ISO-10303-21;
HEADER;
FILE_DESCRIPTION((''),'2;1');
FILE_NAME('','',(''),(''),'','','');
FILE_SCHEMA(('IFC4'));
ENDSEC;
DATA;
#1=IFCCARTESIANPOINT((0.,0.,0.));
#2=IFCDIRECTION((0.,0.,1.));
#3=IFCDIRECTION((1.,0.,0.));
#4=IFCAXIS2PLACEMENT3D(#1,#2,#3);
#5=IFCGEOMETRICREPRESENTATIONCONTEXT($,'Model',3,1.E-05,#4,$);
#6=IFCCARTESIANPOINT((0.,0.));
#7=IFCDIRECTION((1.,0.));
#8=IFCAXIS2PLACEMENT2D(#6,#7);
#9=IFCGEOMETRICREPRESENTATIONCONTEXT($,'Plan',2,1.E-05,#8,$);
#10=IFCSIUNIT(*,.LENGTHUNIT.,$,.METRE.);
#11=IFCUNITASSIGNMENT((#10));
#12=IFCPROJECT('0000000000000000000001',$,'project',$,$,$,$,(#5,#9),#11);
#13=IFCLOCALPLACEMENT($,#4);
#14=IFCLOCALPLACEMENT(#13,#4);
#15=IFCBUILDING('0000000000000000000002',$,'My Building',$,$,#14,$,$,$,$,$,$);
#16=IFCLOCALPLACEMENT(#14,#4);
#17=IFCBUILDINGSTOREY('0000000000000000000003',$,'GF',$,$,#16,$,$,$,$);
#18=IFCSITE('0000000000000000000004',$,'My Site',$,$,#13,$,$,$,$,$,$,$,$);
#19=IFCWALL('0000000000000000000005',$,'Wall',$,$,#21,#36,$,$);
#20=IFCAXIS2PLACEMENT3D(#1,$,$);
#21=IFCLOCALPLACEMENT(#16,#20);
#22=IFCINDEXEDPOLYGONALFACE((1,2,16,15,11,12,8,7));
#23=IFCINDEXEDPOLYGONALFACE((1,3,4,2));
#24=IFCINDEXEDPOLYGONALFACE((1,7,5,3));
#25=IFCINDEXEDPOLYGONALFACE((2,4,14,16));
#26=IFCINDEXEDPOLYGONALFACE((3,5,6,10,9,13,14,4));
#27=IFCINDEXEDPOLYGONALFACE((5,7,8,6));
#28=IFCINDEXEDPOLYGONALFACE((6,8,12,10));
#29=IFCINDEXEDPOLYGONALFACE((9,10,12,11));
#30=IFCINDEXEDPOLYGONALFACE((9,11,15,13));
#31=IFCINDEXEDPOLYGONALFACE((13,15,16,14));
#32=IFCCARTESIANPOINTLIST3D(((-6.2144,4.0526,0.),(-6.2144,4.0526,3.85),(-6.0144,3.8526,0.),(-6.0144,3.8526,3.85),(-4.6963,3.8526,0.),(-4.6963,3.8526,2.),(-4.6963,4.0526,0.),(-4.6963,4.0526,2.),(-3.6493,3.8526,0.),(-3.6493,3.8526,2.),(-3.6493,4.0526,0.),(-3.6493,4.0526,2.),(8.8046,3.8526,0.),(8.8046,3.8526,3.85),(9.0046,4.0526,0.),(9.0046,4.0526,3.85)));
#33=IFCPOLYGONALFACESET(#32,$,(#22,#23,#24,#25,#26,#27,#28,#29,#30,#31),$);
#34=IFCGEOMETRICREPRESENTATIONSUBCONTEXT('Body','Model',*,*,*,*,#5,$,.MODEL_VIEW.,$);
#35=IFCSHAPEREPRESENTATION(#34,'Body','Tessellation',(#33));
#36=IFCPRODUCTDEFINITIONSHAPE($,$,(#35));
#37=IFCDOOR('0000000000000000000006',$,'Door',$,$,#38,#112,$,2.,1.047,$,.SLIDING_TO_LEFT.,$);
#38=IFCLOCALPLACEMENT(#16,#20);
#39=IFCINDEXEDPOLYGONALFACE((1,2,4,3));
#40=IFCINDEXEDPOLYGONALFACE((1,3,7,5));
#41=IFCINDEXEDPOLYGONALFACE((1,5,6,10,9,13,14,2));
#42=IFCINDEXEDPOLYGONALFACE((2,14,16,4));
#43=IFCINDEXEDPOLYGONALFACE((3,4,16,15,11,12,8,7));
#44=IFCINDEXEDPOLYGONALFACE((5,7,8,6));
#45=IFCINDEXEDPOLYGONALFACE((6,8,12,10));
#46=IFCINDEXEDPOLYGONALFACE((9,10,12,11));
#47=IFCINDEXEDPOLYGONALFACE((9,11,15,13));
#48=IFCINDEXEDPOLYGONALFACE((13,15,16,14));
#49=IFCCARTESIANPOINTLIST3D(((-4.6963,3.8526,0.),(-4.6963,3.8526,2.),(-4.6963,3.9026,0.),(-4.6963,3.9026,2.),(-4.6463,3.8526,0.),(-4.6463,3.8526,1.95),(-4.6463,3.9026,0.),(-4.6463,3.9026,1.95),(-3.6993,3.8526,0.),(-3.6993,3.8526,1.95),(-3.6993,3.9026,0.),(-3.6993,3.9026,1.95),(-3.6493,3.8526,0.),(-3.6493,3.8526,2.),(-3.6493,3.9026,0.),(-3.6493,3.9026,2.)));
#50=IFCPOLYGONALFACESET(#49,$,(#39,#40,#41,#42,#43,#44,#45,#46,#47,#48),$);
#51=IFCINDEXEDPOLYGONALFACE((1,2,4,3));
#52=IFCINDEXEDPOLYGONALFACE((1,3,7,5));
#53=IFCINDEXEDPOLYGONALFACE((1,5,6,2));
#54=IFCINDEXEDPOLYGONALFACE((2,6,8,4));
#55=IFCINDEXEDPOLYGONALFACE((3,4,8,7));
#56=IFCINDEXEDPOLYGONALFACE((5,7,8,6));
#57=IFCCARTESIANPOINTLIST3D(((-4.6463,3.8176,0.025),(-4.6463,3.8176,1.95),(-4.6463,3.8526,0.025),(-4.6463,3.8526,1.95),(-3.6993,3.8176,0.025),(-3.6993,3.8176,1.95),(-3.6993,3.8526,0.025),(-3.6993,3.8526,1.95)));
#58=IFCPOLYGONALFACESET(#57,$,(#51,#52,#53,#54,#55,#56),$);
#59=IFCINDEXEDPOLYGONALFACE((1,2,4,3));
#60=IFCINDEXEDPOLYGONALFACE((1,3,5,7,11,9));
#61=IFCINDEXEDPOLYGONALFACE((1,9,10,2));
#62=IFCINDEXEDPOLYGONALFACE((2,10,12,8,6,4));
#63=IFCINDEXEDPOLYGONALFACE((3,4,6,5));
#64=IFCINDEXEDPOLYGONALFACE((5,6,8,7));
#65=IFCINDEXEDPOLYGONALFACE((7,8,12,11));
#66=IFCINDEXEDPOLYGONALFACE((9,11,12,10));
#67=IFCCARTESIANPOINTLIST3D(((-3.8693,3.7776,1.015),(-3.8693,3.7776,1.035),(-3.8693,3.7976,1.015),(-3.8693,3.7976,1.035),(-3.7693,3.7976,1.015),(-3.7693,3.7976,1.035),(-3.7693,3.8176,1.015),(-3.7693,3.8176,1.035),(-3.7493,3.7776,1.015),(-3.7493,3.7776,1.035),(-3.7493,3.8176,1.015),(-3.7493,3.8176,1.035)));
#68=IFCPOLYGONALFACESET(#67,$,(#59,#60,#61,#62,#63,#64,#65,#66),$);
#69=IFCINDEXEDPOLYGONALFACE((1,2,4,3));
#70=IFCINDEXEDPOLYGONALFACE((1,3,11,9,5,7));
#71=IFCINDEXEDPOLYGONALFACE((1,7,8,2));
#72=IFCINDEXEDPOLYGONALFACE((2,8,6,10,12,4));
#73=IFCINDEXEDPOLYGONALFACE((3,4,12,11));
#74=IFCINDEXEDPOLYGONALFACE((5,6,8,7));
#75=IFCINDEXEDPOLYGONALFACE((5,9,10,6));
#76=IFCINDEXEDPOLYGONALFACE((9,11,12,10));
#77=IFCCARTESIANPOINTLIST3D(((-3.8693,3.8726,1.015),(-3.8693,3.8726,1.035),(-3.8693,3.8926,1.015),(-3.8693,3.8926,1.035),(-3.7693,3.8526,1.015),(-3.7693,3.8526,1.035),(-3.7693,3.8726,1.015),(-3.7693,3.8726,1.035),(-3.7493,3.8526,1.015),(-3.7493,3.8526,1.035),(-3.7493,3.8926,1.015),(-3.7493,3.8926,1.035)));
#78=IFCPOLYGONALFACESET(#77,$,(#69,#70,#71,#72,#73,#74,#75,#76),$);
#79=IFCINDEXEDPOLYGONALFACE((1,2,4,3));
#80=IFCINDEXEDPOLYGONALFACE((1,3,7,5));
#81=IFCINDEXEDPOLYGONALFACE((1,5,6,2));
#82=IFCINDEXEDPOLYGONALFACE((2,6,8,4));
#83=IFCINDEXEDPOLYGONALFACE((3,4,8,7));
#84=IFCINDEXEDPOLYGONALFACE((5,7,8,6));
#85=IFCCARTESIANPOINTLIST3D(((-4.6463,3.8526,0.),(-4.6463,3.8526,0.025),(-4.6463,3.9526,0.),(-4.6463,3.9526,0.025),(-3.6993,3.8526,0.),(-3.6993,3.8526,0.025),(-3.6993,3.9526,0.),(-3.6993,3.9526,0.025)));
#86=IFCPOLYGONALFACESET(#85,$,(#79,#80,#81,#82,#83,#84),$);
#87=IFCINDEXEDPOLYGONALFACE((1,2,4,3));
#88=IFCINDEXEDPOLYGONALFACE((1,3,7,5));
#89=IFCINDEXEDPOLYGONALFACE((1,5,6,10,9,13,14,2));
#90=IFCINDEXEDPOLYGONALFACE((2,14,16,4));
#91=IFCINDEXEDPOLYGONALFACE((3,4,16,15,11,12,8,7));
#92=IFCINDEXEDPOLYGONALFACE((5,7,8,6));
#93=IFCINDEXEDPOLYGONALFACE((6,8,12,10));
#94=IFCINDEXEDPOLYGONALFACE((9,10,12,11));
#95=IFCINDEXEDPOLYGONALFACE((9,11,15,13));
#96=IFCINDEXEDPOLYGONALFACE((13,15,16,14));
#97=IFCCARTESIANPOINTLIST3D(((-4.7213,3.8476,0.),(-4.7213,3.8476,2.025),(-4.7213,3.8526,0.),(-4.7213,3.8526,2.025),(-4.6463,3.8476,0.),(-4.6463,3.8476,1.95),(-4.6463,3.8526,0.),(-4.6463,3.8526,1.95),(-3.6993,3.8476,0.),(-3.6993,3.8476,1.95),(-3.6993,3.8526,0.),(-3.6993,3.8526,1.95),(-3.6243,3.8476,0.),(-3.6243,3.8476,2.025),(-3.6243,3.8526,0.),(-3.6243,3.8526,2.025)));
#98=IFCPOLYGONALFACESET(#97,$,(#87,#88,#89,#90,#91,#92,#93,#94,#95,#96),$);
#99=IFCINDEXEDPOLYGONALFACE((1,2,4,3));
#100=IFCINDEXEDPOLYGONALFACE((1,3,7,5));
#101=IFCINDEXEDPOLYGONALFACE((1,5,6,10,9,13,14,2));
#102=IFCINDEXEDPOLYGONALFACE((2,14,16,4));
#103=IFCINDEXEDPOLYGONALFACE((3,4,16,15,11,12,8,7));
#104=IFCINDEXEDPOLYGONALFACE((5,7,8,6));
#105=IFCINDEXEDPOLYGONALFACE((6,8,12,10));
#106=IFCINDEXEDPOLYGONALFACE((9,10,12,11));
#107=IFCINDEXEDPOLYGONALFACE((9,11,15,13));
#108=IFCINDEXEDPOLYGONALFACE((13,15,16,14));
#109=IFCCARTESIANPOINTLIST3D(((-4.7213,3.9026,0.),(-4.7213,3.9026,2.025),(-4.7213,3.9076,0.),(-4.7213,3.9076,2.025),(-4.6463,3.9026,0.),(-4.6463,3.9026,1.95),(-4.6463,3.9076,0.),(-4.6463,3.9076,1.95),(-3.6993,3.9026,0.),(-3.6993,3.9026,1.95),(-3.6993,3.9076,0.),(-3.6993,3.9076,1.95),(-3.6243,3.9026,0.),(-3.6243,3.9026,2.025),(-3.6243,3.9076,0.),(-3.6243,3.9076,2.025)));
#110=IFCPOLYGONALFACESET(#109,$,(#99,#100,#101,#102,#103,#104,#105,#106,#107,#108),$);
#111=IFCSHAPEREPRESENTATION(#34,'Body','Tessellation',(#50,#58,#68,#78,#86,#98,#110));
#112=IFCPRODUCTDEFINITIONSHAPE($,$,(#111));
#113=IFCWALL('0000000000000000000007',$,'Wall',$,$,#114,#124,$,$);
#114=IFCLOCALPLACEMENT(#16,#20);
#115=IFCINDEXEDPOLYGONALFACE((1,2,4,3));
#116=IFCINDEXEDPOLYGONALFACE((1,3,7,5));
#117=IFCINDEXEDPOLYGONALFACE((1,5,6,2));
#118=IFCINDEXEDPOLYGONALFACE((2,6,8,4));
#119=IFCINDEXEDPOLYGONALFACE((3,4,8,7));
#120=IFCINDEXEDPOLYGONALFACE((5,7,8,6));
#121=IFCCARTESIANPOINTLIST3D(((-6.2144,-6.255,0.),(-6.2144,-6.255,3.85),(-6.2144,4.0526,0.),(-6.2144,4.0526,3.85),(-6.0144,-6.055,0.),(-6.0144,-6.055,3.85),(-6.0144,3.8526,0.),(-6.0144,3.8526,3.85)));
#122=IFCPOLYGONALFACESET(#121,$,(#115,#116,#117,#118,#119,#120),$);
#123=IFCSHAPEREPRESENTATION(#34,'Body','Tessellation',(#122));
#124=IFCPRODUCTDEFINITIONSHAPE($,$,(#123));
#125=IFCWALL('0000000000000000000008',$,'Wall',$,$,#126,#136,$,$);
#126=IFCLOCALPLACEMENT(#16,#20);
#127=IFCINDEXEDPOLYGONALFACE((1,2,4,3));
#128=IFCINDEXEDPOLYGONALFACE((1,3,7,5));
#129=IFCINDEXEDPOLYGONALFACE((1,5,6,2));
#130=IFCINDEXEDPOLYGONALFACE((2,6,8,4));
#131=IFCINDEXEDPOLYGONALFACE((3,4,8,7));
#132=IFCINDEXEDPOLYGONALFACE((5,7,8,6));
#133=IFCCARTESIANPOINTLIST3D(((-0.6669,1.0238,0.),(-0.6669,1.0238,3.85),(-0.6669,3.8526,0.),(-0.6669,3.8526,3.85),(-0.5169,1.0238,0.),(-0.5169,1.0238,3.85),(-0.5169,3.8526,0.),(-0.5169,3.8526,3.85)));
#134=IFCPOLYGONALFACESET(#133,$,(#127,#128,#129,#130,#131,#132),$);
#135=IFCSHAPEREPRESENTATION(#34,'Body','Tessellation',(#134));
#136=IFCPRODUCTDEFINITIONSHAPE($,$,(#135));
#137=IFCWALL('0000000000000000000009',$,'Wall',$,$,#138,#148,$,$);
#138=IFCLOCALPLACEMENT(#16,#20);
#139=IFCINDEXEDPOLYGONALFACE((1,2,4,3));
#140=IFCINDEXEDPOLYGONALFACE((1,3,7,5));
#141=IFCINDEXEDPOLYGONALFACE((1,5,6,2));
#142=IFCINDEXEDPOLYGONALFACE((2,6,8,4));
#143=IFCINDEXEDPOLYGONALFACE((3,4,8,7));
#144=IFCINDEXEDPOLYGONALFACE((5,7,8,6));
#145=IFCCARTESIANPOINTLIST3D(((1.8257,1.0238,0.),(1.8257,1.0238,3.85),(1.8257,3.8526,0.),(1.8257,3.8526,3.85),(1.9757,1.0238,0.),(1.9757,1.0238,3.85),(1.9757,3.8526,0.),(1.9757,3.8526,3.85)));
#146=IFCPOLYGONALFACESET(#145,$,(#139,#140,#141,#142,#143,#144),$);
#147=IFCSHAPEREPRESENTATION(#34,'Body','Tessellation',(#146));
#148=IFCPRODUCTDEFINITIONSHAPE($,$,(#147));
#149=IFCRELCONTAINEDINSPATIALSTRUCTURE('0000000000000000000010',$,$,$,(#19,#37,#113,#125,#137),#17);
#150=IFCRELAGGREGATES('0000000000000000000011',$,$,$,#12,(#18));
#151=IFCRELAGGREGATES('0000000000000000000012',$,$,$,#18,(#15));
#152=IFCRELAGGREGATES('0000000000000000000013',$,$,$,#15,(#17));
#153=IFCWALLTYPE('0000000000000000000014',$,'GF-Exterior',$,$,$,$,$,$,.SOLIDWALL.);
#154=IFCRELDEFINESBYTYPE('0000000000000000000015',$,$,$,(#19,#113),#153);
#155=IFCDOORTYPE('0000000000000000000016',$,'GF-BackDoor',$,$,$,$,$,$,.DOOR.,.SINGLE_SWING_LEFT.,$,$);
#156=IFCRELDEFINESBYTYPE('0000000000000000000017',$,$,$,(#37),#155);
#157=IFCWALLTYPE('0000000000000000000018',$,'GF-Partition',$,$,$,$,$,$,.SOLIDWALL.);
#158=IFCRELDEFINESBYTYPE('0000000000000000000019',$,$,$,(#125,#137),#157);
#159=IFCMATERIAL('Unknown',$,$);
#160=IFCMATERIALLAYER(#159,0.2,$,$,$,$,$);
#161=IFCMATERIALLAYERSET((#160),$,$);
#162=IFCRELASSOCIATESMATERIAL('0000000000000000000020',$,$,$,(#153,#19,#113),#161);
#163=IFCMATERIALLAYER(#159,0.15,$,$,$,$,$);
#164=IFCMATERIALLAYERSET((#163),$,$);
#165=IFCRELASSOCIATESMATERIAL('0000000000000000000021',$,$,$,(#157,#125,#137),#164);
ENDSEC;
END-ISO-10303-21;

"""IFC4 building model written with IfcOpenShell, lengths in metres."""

from ifc_helpers import new_model, entity, si_unit, frame, origin_with_axes, origin_2d_with_axis, place, context, subcontext, project, spatial, line, indexed_curve, outline, extrude, shape, source, transform, mapped, material, layer, layer_set, layer_usage, type_object, type_shapes, element, fill, save


model = new_model("IFC4")

# Units and contexts
model_context = context("Model", 3, precision=1e-05, world=origin_with_axes())
plan_context = context("Plan", 2, precision=1e-05, world=origin_2d_with_axis())
body_context_1 = subcontext(model_context, "Body", "Model", "MODEL_VIEW")
body_context_2 = subcontext(plan_context, "Body", "Plan", "PLAN_VIEW")
ifc_project = project(units=[si_unit("LENGTHUNIT", "METRE")], contexts=[model_context, plan_context])

# Site, building, storey
site_placement = place(None, origin_with_axes())
site = spatial("IfcSite", under=ifc_project, at=site_placement, Name="My Site")
building_placement = place(site_placement, origin_with_axes())
building = spatial("IfcBuilding", under=site, at=building_placement, Name="My Building")
storey_placement = place(building_placement, origin_with_axes())
storey = spatial("IfcBuildingStorey", under=building, at=storey_placement, Name="GF")

# Shared definitions
ifc_material = material(Name="Unknown")

# Wall, opening, door
ifc_layer_1 = layer(ifc_material, 0.2)
ifc_layer_set_1 = layer_set([ifc_layer_1])
ifc_layer_usage_1 = layer_usage(ifc_layer_set_1, "AXIS2", "POSITIVE", 0.0)
wall_type_1 = type_object("IfcWallType", Name="GF-Exterior", PredefinedType="SOLIDWALL", material=ifc_layer_set_1)
wall_1_placement = place(storey_placement, frame((-6.0144, 3.8526, 0.0), z_axis=(0.0, 0.0, 1.0), x_axis=(1.0, 0.0, 0.0)))
wall_1 = element("IfcWall", 1, at=wall_1_placement, inside=storey, type_object=wall_type_1, material=ifc_layer_usage_1, Name="Wall", context=body_context_1, shape_type="SweptSolid", body=[
    extrude(outline(indexed_curve([(0.0, 0.0), (-0.2, 0.2), (15.019, 0.2), (14.819, 0.0)], segments=[line(1, 2, 3, 4, 1)])), origin_with_axes(), (0.0, 0.0, 1.0), 3.85),
])
shared_shape_1 = source(origin_with_axes(), body_context_1, "Body", "SweptSolid", [
    extrude(outline(indexed_curve([(0.0, 0.0), (1.047, 0.0), (1.047, 2.0), (0.0, 2.0)], segments=[line(1, 2, 3, 4, 1)])), frame((0.0, -0.6, 0.0), z_axis=(0.0, -1.0, 0.0), x_axis=(1.0, 0.0, 0.0)), (0.0, 0.0, -1.0), 1.2),
])
opening_placement = place(wall_1_placement, frame((1.3181, 0.0, 0.0), z_axis=(0.0, 0.0, 1.0), x_axis=(1.0, 0.0, 0.0)))
opening = element("IfcOpeningElement", 2, at=opening_placement, cuts=wall_1, PredefinedType="OPENING", context=body_context_1, shape_type="MappedRepresentation", body=[
    mapped(shared_shape_1, transform((0.0, 0.0, 0.0), x_axis=(1.0, 0.0, 0.0), y_axis=(0.0, 1.0, 0.0), z_axis=(0.0, 0.0, 1.0), scale=1.0)),
])
door_type = type_object("IfcDoorType", Name="GF-BackDoor", OperationType="SINGLE_SWING_LEFT", PredefinedType="DOOR")
shared_shape_2 = source(origin_with_axes(), body_context_1, "Body", "SweptSolid", [
    extrude(outline(indexed_curve([(0.0, 0.0), (0.0, 2.0), (1.047, 2.0), (1.047, 0.0), (0.997, 0.0), (0.997, 1.95), (0.05, 1.95), (0.05, 0.0)], segments=[line(1, 2, 3, 4, 5, 6, 7, 8, 1)])), frame((0.0, 0.0, 0.0), z_axis=(0.0, -1.0, 0.0), x_axis=(1.0, 0.0, 0.0)), (0.0, 0.0, -1.0), 0.05),
    extrude(outline(indexed_curve([(0.0, 0.0), (0.947, 0.0), (0.947, 0.035), (0.0, 0.035)], segments=[line(1, 2, 3, 4, 1)])), frame((0.05, -0.035, 0.025), z_axis=(0.0, 0.0, 1.0), x_axis=(1.0, 0.0, 0.0)), (0.0, 0.0, 1.0), 1.925),
    extrude(outline(indexed_curve([(0.0, 0.0), (0.0, -0.04), (-0.12, -0.04), (-0.12, -0.02), (-0.02, -0.02), (-0.02, 0.0)], segments=[line(1, 2, 3, 4, 5, 6, 1)])), frame((0.947, -0.035, 1.015), z_axis=(0.0, 0.0, 1.0), x_axis=(1.0, 0.0, 0.0)), (0.0, 0.0, 1.0), 0.02),
    extrude(outline(indexed_curve([(0.0, 0.0), (0.0, 0.04), (-0.12, 0.04), (-0.12, 0.02), (-0.02, 0.02), (-0.02, 0.0)], segments=[line(1, 2, 3, 4, 5, 6, 1)])), frame((0.947, 0.0, 1.015), z_axis=(0.0, 0.0, 1.0), x_axis=(1.0, 0.0, 0.0)), (0.0, 0.0, 1.0), 0.02),
    extrude(outline(indexed_curve([(0.0, 0.0), (0.947, 0.0), (0.947, 0.1), (0.0, 0.1)], segments=[line(1, 2, 3, 4, 1)])), frame((0.05, 0.0, 0.0), z_axis=(0.0, 0.0, 1.0), x_axis=(1.0, 0.0, 0.0)), (0.0, 0.0, 1.0), 0.025),
    extrude(outline(indexed_curve([(0.0, 0.0), (0.0, 2.025), (1.097, 2.025), (1.097, 0.0), (1.022, 0.0), (1.022, 1.95), (0.075, 1.95), (0.075, 0.0)], segments=[line(1, 2, 3, 4, 5, 6, 7, 8, 1)])), frame((-0.025, -0.005, 0.0), z_axis=(0.0, -1.0, 0.0), x_axis=(1.0, 0.0, 0.0)), (0.0, 0.0, -1.0), 0.005),
    extrude(outline(indexed_curve([(0.0, 0.0), (0.0, 2.025), (1.097, 2.025), (1.097, 0.0), (1.022, 0.0), (1.022, 1.95), (0.075, 1.95), (0.075, 0.0)], segments=[line(1, 2, 3, 4, 5, 6, 7, 8, 1)])), frame((-0.025, 0.05, 0.0), z_axis=(0.0, -1.0, 0.0), x_axis=(1.0, 0.0, 0.0)), (0.0, 0.0, -1.0), 0.005),
])
shared_shape_3 = source(origin_with_axes(), body_context_2, "Body", "Curve2D", [
    entity("IfcIndexedPolyCurve", entity("IfcCartesianPointList2D", [[0.0, 0.0], [0.05, 0.0], [0.05, 0.05], [0.0, 0.05]]), [entity("IfcLineIndex", [1, 2, 3, 4, 1])]),
    entity("IfcIndexedPolyCurve", entity("IfcCartesianPointList2D", [[1.047, 0.0], [0.997, 0.0], [0.997, 0.05], [1.047, 0.05]]), [entity("IfcLineIndex", [1, 2, 3, 4, 1])]),
    entity("IfcIndexedPolyCurve", entity("IfcCartesianPointList2D", [[-0.4235, -0.035], [0.5235, -0.035], [0.5235, 0.0], [-0.4235, 0.0]]), [entity("IfcLineIndex", [1, 2, 3, 4, 1])]),
])
type_shapes(door_type, [shared_shape_2, shared_shape_3])
door_placement = place(opening_placement, frame((0.0, 0.0, 0.0), z_axis=(0.0, 0.0, 1.0), x_axis=(1.0, 0.0, 0.0)))
door = element("IfcDoor", 3, at=door_placement, inside=storey, type_object=door_type, Name="Door", OperationType="SLIDING_TO_LEFT", OverallHeight=2.0, OverallWidth=1.047, shapes=[
    shape(body_context_1, "Body", "MappedRepresentation", [mapped(shared_shape_2, transform((0.0, 0.0, 0.0), x_axis=(1.0, 0.0, 0.0), y_axis=(0.0, 1.0, 0.0), z_axis=(0.0, 0.0, 1.0), scale=1.0))]),
    shape(body_context_2, "Body", "MappedRepresentation", [mapped(shared_shape_3, transform((0.0, 0.0, 0.0), x_axis=(1.0, 0.0, 0.0), y_axis=(0.0, 1.0, 0.0), z_axis=(0.0, 0.0, 1.0), scale=1.0))]),
])
fill(opening, door)

# Walls
ifc_layer_usage_2 = layer_usage(ifc_layer_set_1, "AXIS2", "POSITIVE", 0.0)
wall_2_placement = place(storey_placement, frame((-6.0144, -6.055, 0.0), z_axis=(0.0, 0.0, 1.0), x_axis=(0.0, 1.0, 0.0)))
element("IfcWall", 4, at=wall_2_placement, inside=storey, type_object=wall_type_1, material=ifc_layer_usage_2, Name="Wall", context=body_context_1, shape_type="SweptSolid", body=[
    extrude(outline(indexed_curve([(0.0, 0.0), (-0.2, 0.2), (10.1077, 0.2), (9.9077, 0.0)], segments=[line(1, 2, 3, 4, 1)])), origin_with_axes(), (0.0, 0.0, 1.0), 3.85),
])
ifc_layer_2 = layer(ifc_material, 0.15)
ifc_layer_set_2 = layer_set([ifc_layer_2])
ifc_layer_usage_3 = layer_usage(ifc_layer_set_2, "AXIS2", "POSITIVE", 0.0)
wall_type_2 = type_object("IfcWallType", Name="GF-Partition", PredefinedType="SOLIDWALL", material=ifc_layer_set_2)
wall_3_placement = place(storey_placement, frame((-0.5169, 1.0238, 0.0), z_axis=(0.0, 0.0, 1.0), x_axis=(0.0, 1.0, 0.0)))
element("IfcWall", 5, at=wall_3_placement, inside=storey, type_object=wall_type_2, material=ifc_layer_usage_3, Name="Wall", context=body_context_1, shape_type="SweptSolid", body=[
    extrude(outline(indexed_curve([(0.0, 0.0), (0.0, 0.15), (2.8288, 0.15), (2.8288, 0.0)], segments=[line(1, 2, 3, 4, 1)])), origin_with_axes(), (0.0, 0.0, 1.0), 3.85),
])
ifc_layer_usage_4 = layer_usage(ifc_layer_set_2, "AXIS2", "POSITIVE", 0.0)
wall_4_placement = place(storey_placement, frame((1.9757, 1.0238, 0.0), z_axis=(0.0, 0.0, 1.0), x_axis=(0.0, 1.0, 0.0)))
element("IfcWall", 6, at=wall_4_placement, inside=storey, type_object=wall_type_2, material=ifc_layer_usage_4, Name="Wall", context=body_context_1, shape_type="SweptSolid", body=[
    extrude(outline(indexed_curve([(0.0, 0.0), (0.0, 0.15), (2.8288, 0.15), (2.8288, 0.0)], segments=[line(1, 2, 3, 4, 1)])), origin_with_axes(), (0.0, 0.0, 1.0), 3.85),
])

save(model, "model.ifc")
